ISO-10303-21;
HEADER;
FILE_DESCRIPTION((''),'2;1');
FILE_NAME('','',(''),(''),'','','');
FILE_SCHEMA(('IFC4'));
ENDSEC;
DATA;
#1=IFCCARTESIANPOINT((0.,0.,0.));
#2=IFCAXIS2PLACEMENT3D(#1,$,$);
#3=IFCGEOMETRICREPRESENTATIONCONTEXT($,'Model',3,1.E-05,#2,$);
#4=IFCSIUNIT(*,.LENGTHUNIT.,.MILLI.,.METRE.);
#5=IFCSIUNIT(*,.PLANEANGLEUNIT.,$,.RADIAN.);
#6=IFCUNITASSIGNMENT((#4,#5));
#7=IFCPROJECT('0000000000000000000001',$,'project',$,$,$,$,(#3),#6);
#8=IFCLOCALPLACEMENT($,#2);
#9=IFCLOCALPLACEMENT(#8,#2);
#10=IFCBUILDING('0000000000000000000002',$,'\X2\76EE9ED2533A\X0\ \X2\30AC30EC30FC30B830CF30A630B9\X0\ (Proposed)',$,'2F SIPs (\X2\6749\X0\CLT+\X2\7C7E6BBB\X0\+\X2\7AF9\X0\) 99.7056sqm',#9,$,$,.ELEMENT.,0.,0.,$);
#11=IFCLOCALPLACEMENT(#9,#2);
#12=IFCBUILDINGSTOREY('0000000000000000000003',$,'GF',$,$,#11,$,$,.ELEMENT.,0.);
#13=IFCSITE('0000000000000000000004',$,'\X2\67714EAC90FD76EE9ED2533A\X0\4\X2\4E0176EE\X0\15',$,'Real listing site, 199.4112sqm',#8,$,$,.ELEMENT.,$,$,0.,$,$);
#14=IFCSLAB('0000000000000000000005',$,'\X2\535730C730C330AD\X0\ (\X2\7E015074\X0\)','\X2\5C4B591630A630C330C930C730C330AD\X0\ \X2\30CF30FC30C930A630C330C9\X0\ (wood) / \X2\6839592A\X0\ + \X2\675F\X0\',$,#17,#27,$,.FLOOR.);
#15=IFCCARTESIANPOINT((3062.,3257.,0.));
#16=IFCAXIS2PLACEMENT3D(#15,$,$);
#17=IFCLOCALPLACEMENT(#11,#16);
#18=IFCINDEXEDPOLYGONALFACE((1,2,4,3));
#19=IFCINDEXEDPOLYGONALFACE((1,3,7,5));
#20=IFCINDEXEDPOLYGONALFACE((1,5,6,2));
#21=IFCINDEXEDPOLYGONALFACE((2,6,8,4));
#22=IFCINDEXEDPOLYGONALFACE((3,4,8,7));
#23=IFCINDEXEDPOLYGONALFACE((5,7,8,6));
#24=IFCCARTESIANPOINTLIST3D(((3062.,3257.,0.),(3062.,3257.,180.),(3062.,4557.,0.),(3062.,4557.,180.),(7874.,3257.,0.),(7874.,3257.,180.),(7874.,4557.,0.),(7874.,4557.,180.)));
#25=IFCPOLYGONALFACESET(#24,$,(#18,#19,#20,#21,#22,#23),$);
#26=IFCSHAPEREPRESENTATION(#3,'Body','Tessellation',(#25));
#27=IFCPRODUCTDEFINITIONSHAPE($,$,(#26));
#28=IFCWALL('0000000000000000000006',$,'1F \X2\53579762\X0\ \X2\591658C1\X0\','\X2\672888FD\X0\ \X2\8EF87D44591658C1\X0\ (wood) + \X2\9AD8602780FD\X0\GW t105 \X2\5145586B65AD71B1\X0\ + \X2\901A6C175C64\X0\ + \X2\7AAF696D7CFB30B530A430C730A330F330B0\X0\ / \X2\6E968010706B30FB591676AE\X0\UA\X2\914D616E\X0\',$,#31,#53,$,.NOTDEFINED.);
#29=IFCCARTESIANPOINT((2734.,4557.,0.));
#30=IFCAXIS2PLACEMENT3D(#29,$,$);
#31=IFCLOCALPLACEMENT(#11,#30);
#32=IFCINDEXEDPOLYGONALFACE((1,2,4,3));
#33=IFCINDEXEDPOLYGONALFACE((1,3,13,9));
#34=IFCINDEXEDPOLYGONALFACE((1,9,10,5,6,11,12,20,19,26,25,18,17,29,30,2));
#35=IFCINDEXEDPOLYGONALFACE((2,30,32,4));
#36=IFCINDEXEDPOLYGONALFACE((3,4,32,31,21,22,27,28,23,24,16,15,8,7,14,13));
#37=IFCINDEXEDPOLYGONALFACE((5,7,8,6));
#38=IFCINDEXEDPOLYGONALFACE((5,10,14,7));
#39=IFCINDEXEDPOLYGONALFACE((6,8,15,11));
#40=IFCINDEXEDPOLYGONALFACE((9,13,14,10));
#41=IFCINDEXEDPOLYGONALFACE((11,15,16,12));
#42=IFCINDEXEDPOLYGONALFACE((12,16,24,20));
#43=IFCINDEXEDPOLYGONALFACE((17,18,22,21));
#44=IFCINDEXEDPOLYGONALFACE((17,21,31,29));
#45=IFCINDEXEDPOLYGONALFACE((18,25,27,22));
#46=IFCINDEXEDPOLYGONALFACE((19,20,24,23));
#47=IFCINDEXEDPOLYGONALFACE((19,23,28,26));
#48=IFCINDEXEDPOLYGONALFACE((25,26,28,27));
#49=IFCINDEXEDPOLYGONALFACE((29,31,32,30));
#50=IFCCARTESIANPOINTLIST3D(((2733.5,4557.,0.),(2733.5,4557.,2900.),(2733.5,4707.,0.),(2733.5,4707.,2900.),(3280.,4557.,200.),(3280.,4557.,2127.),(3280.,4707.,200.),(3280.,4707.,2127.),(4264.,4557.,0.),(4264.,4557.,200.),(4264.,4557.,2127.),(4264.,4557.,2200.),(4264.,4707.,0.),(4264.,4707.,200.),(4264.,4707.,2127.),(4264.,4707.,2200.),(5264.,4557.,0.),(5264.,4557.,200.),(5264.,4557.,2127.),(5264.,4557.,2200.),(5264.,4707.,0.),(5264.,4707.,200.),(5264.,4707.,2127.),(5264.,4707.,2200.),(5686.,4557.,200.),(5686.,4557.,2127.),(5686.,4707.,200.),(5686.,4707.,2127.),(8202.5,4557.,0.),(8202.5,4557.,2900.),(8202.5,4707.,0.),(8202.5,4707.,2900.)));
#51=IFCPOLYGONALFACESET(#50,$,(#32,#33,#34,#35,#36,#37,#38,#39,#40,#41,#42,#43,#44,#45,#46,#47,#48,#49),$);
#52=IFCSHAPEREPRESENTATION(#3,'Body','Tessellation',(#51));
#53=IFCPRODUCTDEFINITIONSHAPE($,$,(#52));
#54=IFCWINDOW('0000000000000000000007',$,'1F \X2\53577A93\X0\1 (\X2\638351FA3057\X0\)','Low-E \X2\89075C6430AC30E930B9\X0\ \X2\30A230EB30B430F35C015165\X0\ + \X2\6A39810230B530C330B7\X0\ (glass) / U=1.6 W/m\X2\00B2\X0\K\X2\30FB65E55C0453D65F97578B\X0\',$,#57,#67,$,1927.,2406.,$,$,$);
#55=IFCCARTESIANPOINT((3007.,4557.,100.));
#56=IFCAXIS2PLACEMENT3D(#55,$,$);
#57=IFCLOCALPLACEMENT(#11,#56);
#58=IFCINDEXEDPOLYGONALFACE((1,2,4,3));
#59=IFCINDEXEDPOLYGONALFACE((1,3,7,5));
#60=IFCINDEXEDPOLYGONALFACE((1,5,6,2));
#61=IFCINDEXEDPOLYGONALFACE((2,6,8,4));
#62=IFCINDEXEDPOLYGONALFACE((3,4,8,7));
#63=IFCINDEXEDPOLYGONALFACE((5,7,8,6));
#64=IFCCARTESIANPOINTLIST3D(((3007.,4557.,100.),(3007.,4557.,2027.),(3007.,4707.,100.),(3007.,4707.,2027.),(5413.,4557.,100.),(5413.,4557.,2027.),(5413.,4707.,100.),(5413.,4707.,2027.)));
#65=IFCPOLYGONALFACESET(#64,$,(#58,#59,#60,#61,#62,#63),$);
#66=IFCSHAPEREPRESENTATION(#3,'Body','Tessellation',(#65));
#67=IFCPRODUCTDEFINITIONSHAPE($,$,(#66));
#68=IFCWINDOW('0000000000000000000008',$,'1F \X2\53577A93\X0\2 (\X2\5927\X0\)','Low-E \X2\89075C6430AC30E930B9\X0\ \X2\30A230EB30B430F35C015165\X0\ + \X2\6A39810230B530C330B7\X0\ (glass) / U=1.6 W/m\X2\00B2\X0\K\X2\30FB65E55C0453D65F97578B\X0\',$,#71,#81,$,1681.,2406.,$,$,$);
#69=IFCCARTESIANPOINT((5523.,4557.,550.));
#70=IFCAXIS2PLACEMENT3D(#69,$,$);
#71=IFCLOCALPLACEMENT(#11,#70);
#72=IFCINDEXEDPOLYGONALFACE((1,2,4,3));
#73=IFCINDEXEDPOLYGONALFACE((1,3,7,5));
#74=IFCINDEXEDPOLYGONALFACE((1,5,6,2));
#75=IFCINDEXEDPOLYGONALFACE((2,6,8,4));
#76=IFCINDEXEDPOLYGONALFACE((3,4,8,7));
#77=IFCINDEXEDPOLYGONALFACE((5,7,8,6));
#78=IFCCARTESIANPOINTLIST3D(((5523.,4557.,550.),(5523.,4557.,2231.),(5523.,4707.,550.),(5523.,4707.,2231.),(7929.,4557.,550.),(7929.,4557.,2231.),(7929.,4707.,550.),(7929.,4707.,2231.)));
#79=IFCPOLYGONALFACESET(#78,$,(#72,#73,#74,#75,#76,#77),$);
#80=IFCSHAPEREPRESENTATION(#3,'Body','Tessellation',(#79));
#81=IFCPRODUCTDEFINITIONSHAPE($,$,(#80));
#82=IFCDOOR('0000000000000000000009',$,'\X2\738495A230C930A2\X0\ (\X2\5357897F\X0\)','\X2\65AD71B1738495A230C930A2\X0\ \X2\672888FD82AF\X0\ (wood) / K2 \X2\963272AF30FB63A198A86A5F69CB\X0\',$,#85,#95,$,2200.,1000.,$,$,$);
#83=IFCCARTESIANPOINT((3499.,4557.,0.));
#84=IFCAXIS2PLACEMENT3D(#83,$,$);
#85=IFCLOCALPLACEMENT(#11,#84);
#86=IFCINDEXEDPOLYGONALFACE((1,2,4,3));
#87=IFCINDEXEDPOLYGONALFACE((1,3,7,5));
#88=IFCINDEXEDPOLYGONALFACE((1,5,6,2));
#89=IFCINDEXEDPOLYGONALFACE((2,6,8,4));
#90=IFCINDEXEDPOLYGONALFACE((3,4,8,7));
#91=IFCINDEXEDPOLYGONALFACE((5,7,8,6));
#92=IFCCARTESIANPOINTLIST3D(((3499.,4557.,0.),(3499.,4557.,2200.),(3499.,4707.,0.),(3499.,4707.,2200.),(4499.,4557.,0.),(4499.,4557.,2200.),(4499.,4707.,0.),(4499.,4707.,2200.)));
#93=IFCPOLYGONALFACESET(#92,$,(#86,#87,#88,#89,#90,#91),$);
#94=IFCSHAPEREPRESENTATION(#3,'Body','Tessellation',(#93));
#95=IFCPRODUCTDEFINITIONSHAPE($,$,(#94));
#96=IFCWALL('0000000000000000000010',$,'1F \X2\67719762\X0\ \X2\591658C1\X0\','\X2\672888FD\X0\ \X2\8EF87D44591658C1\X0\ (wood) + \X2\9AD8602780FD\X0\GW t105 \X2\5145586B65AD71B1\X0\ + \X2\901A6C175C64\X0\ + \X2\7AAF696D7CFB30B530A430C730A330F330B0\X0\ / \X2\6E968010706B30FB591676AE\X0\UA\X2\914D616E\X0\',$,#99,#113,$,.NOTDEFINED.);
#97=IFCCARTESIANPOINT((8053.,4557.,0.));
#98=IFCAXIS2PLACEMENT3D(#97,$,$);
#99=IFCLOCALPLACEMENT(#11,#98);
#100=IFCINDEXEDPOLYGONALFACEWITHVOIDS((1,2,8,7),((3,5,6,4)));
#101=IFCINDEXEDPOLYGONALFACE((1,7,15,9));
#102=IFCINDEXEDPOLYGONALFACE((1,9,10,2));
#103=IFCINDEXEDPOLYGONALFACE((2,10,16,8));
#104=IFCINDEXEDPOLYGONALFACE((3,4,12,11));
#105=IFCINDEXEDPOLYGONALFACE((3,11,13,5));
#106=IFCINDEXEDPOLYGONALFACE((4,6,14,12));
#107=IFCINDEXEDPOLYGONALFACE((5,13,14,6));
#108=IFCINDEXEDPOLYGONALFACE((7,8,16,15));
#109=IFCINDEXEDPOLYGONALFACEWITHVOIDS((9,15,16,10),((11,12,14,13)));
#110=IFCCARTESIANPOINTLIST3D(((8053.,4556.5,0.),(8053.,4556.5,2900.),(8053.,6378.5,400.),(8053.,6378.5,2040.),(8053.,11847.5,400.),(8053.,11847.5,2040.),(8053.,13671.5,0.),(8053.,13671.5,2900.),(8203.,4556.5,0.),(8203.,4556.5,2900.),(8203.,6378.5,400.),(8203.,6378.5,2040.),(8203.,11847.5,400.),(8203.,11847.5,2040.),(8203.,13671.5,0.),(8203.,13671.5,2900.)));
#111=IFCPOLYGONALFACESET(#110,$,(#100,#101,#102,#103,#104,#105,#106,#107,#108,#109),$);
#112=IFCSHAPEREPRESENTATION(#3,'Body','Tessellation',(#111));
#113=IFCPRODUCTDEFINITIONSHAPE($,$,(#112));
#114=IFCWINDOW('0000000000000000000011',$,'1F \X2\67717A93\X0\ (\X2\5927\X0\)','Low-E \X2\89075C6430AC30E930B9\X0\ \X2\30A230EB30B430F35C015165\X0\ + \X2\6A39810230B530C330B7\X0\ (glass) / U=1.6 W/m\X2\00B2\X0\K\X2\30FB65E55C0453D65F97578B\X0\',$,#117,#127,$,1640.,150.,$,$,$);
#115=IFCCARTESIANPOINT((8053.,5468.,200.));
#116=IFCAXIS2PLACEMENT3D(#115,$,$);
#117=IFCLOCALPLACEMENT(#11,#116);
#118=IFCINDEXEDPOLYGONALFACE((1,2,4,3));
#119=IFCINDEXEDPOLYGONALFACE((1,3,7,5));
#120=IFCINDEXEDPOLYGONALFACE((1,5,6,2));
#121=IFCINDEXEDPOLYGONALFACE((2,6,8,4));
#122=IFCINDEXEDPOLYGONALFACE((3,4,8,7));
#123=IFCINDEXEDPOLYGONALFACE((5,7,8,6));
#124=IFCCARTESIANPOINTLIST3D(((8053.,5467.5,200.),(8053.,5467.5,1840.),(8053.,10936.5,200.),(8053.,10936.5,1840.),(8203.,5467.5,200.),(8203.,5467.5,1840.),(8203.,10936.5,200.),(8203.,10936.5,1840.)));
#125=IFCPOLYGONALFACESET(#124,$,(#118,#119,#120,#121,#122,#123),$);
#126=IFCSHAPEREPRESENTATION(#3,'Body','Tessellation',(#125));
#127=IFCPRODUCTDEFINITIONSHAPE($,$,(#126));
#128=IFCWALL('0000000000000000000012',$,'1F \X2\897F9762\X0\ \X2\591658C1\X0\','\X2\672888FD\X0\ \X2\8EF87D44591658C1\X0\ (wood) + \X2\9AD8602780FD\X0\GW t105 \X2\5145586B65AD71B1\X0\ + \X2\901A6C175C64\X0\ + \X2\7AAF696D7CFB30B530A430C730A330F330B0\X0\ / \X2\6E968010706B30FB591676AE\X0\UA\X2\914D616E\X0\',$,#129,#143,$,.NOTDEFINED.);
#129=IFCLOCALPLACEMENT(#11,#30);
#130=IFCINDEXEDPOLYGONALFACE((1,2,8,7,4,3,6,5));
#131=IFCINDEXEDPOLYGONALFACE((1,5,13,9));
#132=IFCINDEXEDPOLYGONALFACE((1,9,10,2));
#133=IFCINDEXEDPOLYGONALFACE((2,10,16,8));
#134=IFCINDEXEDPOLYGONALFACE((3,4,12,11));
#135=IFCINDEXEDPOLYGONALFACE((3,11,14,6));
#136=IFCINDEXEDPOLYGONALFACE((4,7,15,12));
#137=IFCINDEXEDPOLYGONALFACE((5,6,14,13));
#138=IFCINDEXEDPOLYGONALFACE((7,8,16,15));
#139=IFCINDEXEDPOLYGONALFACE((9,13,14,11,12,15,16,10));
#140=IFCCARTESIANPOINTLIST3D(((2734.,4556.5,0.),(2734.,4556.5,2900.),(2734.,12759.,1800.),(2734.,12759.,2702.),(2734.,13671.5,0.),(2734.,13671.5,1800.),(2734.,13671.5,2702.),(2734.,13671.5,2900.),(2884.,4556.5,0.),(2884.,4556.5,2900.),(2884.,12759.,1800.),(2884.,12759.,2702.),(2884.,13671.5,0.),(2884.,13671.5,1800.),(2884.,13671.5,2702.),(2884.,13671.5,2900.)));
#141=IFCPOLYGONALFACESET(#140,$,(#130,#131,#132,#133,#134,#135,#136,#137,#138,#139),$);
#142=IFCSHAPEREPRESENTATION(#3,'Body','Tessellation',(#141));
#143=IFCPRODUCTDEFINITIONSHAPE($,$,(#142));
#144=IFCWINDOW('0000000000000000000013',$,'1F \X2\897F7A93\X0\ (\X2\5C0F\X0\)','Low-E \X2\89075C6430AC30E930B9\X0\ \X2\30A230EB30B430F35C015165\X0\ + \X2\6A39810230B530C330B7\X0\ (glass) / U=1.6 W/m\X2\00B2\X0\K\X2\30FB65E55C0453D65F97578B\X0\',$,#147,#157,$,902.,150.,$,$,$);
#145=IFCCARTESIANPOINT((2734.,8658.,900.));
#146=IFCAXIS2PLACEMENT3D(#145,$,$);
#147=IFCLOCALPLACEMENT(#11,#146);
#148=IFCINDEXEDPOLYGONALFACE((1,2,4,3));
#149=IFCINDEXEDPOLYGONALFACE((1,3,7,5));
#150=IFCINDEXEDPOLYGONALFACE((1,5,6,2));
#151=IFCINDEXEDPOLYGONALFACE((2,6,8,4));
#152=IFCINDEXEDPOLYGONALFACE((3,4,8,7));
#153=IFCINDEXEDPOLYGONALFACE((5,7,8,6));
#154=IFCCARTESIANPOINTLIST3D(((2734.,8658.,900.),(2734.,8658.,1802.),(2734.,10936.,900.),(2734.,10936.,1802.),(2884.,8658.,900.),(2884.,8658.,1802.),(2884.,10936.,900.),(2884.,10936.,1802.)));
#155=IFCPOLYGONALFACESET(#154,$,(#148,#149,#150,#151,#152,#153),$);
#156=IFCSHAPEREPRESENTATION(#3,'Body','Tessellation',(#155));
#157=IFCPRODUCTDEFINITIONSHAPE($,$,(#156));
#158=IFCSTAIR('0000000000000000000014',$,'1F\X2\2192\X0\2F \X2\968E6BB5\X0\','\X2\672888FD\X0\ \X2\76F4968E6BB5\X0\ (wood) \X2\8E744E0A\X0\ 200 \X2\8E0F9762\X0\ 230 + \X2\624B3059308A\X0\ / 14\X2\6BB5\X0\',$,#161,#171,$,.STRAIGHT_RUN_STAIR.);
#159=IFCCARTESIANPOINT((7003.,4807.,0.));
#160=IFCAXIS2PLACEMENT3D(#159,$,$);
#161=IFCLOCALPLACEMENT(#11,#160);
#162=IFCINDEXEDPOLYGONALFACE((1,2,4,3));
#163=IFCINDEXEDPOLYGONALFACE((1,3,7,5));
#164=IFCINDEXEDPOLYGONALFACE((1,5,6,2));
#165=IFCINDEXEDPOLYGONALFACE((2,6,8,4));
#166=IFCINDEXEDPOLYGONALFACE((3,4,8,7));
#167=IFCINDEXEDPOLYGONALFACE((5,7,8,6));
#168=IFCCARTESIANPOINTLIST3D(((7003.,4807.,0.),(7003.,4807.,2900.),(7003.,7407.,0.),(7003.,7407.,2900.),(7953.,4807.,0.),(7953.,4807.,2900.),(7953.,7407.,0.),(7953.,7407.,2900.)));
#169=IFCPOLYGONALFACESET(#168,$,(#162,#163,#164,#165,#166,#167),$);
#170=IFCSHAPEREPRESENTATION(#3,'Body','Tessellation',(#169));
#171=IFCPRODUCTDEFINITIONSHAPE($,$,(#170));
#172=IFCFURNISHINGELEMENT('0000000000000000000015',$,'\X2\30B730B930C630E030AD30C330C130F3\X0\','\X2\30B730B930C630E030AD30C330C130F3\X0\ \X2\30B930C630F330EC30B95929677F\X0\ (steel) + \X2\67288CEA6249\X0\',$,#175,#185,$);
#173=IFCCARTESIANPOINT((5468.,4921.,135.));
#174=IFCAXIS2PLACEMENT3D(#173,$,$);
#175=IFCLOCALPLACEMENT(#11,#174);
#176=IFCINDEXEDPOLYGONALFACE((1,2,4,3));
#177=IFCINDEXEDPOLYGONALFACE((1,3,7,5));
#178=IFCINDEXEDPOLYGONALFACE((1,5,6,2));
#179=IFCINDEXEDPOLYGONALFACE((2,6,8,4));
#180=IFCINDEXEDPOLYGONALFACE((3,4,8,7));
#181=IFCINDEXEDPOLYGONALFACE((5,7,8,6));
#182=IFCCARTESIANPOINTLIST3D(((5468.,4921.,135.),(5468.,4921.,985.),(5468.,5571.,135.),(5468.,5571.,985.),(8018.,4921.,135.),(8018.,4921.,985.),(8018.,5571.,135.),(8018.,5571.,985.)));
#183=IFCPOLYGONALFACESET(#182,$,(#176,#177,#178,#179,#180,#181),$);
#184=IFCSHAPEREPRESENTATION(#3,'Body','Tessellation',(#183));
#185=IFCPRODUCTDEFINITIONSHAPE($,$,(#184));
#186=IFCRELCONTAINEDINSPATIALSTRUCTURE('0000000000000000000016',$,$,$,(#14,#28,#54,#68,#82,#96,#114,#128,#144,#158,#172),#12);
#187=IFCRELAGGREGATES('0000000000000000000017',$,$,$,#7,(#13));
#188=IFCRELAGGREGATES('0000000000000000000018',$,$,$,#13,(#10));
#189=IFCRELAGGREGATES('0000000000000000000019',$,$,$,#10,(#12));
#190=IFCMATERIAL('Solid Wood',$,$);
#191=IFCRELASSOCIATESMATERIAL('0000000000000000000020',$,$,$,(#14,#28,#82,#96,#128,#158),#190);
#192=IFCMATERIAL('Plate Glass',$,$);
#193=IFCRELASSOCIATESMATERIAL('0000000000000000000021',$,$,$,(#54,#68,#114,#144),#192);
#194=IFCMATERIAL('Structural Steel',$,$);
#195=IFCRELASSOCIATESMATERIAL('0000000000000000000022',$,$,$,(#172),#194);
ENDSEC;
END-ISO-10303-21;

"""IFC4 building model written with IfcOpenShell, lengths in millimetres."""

from ifc_helpers import new_model, si_unit, frame, frame_2d, origin, place, context, project, spatial, rectangle, extrude, material, element, fill, save


model = new_model("IFC4")

# Units and contexts
model_context = context("Model", 3, precision=1e-05, world=origin())
ifc_project = project(units=[si_unit("LENGTHUNIT", "METRE", prefix="MILLI"), si_unit("PLANEANGLEUNIT", "RADIAN")], contexts=[model_context])

# Site, building, storey
site_placement = place(None, origin())
site = spatial("IfcSite", under=ifc_project, at=site_placement, Name="東京都目黒区4丁目15", ObjectType="Real listing site, 199.4112sqm", CompositionType="ELEMENT", RefElevation=0.0)
building_placement = place(site_placement, origin())
building = spatial("IfcBuilding", under=site, at=building_placement, Name="目黒区 ガレージハウス (Proposed)", ObjectType="2F SIPs (杉CLT+籾殻+竹) 99.7056sqm", CompositionType="ELEMENT", ElevationOfRefHeight=0.0, ElevationOfTerrain=0.0)
storey_placement = place(building_placement, origin())
storey = spatial("IfcBuildingStorey", under=building, at=storey_placement, Name="GF", CompositionType="ELEMENT", Elevation=0.0)

# Slab
ifc_material_1 = material(Name="Solid Wood")
slab_1_placement = place(storey_placement, frame((3062.0, 3257.0, 0.0)))
element("IfcSlab", 1, at=slab_1_placement, inside=storey, material=ifc_material_1, Name="南デッキ (縁側)", Description="屋外ウッドデッキ ハードウッド (wood) / 根太 + 束", PredefinedType="FLOOR", context=model_context, shape_type="SweptSolid", body=[
    extrude(rectangle(XDim=4812.0, YDim=1300.0, at=frame_2d((2406.0, 650.0))), frame((3062.0, 3257.0, 0.0)), (0.0, 0.0, 1.0), 180.0),
])

# Wall, openings, windows, door
wall_1_placement = place(storey_placement, frame((2734.0, 4557.0, 0.0)))
wall_1 = element("IfcWall", 2, at=wall_1_placement, inside=storey, material=ifc_material_1, Name="1F 南面 外壁", Description="木製 軸組外壁 (wood) + 高性能GW t105 充填断熱 + 通気層 + 窯業系サイディング / 準耐火・外皮UA配慮", PredefinedType="NOTDEFINED", context=model_context, shape_type="SweptSolid", body=[
    extrude(rectangle(XDim=5469.0, YDim=150.0, at=frame_2d((2734.0, 75.0))), frame((2734.0, 4557.0, 0.0)), (0.0, 0.0, 1.0), 2900.0),
])
opening_1_placement = place(storey_placement, frame((3007.0, 4557.0, 100.0)))
opening_1 = element("IfcOpeningElement", 3, at=opening_1_placement, cuts=wall_1, PredefinedType="NOTDEFINED", context=model_context, shape_type="SweptSolid", body=[
    extrude(rectangle(XDim=2406.0, YDim=150.0, at=frame_2d((1203.0, 75.0))), frame((3007.0, 4557.0, 100.0)), (0.0, 0.0, 1.0), 1927.0),
])
opening_2_placement = place(storey_placement, frame((5523.0, 4557.0, 550.0)))
opening_2 = element("IfcOpeningElement", 4, at=opening_2_placement, cuts=wall_1, PredefinedType="NOTDEFINED", context=model_context, shape_type="SweptSolid", body=[
    extrude(rectangle(XDim=2406.0, YDim=150.0, at=frame_2d((1203.0, 75.0))), frame((5523.0, 4557.0, 550.0)), (0.0, 0.0, 1.0), 1681.0),
])
opening_3_placement = place(storey_placement, frame((3499.0, 4557.0, 0.0)))
opening_3 = element("IfcOpeningElement", 5, at=opening_3_placement, cuts=wall_1, PredefinedType="NOTDEFINED", context=model_context, shape_type="SweptSolid", body=[
    extrude(rectangle(XDim=1000.0, YDim=150.0, at=frame_2d((500.0, 75.0))), frame((3499.0, 4557.0, 0.0)), (0.0, 0.0, 1.0), 2200.0),
])
ifc_material_2 = material(Name="Plate Glass")
window_1_placement = place(storey_placement, frame((3007.0, 4557.0, 100.0)))
window_1 = element("IfcWindow", 6, at=window_1_placement, inside=storey, material=ifc_material_2, Name="1F 南窓1 (掃出し)", Description="Low-E 複層ガラス アルゴン封入 + 樹脂サッシ (glass) / U=1.6 W/m²K・日射取得型", OverallHeight=1927.0, OverallWidth=2406.0, context=model_context, shape_type="SweptSolid", body=[
    extrude(rectangle(XDim=2406.0, YDim=150.0, at=frame_2d((1203.0, 75.0))), frame((3007.0, 4557.0, 100.0)), (0.0, 0.0, 1.0), 1927.0),
])
fill(opening_1, window_1)
window_2_placement = place(storey_placement, frame((5523.0, 4557.0, 550.0)))
window_2 = element("IfcWindow", 7, at=window_2_placement, inside=storey, material=ifc_material_2, Name="1F 南窓2 (大)", Description="Low-E 複層ガラス アルゴン封入 + 樹脂サッシ (glass) / U=1.6 W/m²K・日射取得型", OverallHeight=1681.0, OverallWidth=2406.0, context=model_context, shape_type="SweptSolid", body=[
    extrude(rectangle(XDim=2406.0, YDim=150.0, at=frame_2d((1203.0, 75.0))), frame((5523.0, 4557.0, 550.0)), (0.0, 0.0, 1.0), 1681.0),
])
fill(opening_2, window_2)
door_placement = place(storey_placement, frame((3499.0, 4557.0, 0.0)))
door = element("IfcDoor", 8, at=door_placement, inside=storey, material=ifc_material_1, Name="玄関ドア (南西)", Description="断熱玄関ドア 木製芯 (wood) / K2 防犯・採風機構", OverallHeight=2200.0, OverallWidth=1000.0, context=model_context, shape_type="SweptSolid", body=[
    extrude(rectangle(XDim=1000.0, YDim=150.0, at=frame_2d((500.0, 75.0))), frame((3499.0, 4557.0, 0.0)), (0.0, 0.0, 1.0), 2200.0),
])
fill(opening_3, door)

# Walls, openings, windows
wall_2_placement = place(storey_placement, frame((8053.0, 4557.0, 0.0)))
wall_2 = element("IfcWall", 9, at=wall_2_placement, inside=storey, material=ifc_material_1, Name="1F 東面 外壁", Description="木製 軸組外壁 (wood) + 高性能GW t105 充填断熱 + 通気層 + 窯業系サイディング / 準耐火・外皮UA配慮", PredefinedType="NOTDEFINED", context=model_context, shape_type="SweptSolid", body=[
    extrude(rectangle(XDim=150.0, YDim=9115.0, at=frame_2d((75.0, 4557.0))), frame((8053.0, 4557.0, 0.0)), (0.0, 0.0, 1.0), 2900.0),
])
opening_4_placement = place(storey_placement, frame((8053.0, 5468.0, 200.0)))
opening_4 = element("IfcOpeningElement", 10, at=opening_4_placement, cuts=wall_2, PredefinedType="NOTDEFINED", context=model_context, shape_type="SweptSolid", body=[
    extrude(rectangle(XDim=150.0, YDim=5469.0, at=frame_2d((75.0, 2734.0))), frame((8053.0, 5468.0, 200.0)), (0.0, 0.0, 1.0), 1640.0),
])
window_3_placement = place(storey_placement, frame((8053.0, 5468.0, 200.0)))
window_3 = element("IfcWindow", 11, at=window_3_placement, inside=storey, material=ifc_material_2, Name="1F 東窓 (大)", Description="Low-E 複層ガラス アルゴン封入 + 樹脂サッシ (glass) / U=1.6 W/m²K・日射取得型", OverallHeight=1640.0, OverallWidth=150.0, context=model_context, shape_type="SweptSolid", body=[
    extrude(rectangle(XDim=150.0, YDim=5469.0, at=frame_2d((75.0, 2734.0))), frame((8053.0, 5468.0, 200.0)), (0.0, 0.0, 1.0), 1640.0),
])
fill(opening_4, window_3)
wall_3_placement = place(storey_placement, frame((2734.0, 4557.0, 0.0)))
wall_3 = element("IfcWall", 12, at=wall_3_placement, inside=storey, material=ifc_material_1, Name="1F 西面 外壁", Description="木製 軸組外壁 (wood) + 高性能GW t105 充填断熱 + 通気層 + 窯業系サイディング / 準耐火・外皮UA配慮", PredefinedType="NOTDEFINED", context=model_context, shape_type="SweptSolid", body=[
    extrude(rectangle(XDim=150.0, YDim=9115.0, at=frame_2d((75.0, 4557.0))), frame((2734.0, 4557.0, 0.0)), (0.0, 0.0, 1.0), 2900.0),
])
opening_5_placement = place(storey_placement, frame((2734.0, 8658.0, 900.0)))
opening_5 = element("IfcOpeningElement", 13, at=opening_5_placement, cuts=wall_3, PredefinedType="NOTDEFINED", context=model_context, shape_type="SweptSolid", body=[
    extrude(rectangle(XDim=150.0, YDim=2278.0, at=frame_2d((75.0, 1139.0))), frame((2734.0, 8658.0, 900.0)), (0.0, 0.0, 1.0), 902.0),
])
window_4_placement = place(storey_placement, frame((2734.0, 8658.0, 900.0)))
window_4 = element("IfcWindow", 14, at=window_4_placement, inside=storey, material=ifc_material_2, Name="1F 西窓 (小)", Description="Low-E 複層ガラス アルゴン封入 + 樹脂サッシ (glass) / U=1.6 W/m²K・日射取得型", OverallHeight=902.0, OverallWidth=150.0, context=model_context, shape_type="SweptSolid", body=[
    extrude(rectangle(XDim=150.0, YDim=2278.0, at=frame_2d((75.0, 1139.0))), frame((2734.0, 8658.0, 900.0)), (0.0, 0.0, 1.0), 902.0),
])
fill(opening_5, window_4)

# Stair
stair_placement = place(storey_placement, frame((7003.0, 4807.0, 0.0)))
element("IfcStair", 15, at=stair_placement, inside=storey, material=ifc_material_1, Name="1F→2F 階段", Description="木製 直階段 (wood) 蹴上 200 踏面 230 + 手すり / 14段", PredefinedType="STRAIGHT_RUN_STAIR", context=model_context, shape_type="SweptSolid", body=[
    extrude(rectangle(XDim=950.0, YDim=2600.0, at=frame_2d((475.0, 1300.0))), frame((7003.0, 4807.0, 0.0)), (0.0, 0.0, 1.0), 2900.0),
])

# Furnishing element
ifc_material_3 = material(Name="Structural Steel")
furnishing_placement = place(storey_placement, frame((5468.0, 4921.0, 135.0)))
element("IfcFurnishingElement", 16, at=furnishing_placement, inside=storey, material=ifc_material_3, Name="システムキッチン", Description="システムキッチン ステンレス天板 (steel) + 木質扉", context=model_context, shape_type="SweptSolid", body=[
    extrude(rectangle(XDim=2550.0, YDim=650.0, at=frame_2d((1275.0, 325.0))), frame((5468.0, 4921.0, 135.0)), (0.0, 0.0, 1.0), 850.0),
])

save(model, "model.ifc")
